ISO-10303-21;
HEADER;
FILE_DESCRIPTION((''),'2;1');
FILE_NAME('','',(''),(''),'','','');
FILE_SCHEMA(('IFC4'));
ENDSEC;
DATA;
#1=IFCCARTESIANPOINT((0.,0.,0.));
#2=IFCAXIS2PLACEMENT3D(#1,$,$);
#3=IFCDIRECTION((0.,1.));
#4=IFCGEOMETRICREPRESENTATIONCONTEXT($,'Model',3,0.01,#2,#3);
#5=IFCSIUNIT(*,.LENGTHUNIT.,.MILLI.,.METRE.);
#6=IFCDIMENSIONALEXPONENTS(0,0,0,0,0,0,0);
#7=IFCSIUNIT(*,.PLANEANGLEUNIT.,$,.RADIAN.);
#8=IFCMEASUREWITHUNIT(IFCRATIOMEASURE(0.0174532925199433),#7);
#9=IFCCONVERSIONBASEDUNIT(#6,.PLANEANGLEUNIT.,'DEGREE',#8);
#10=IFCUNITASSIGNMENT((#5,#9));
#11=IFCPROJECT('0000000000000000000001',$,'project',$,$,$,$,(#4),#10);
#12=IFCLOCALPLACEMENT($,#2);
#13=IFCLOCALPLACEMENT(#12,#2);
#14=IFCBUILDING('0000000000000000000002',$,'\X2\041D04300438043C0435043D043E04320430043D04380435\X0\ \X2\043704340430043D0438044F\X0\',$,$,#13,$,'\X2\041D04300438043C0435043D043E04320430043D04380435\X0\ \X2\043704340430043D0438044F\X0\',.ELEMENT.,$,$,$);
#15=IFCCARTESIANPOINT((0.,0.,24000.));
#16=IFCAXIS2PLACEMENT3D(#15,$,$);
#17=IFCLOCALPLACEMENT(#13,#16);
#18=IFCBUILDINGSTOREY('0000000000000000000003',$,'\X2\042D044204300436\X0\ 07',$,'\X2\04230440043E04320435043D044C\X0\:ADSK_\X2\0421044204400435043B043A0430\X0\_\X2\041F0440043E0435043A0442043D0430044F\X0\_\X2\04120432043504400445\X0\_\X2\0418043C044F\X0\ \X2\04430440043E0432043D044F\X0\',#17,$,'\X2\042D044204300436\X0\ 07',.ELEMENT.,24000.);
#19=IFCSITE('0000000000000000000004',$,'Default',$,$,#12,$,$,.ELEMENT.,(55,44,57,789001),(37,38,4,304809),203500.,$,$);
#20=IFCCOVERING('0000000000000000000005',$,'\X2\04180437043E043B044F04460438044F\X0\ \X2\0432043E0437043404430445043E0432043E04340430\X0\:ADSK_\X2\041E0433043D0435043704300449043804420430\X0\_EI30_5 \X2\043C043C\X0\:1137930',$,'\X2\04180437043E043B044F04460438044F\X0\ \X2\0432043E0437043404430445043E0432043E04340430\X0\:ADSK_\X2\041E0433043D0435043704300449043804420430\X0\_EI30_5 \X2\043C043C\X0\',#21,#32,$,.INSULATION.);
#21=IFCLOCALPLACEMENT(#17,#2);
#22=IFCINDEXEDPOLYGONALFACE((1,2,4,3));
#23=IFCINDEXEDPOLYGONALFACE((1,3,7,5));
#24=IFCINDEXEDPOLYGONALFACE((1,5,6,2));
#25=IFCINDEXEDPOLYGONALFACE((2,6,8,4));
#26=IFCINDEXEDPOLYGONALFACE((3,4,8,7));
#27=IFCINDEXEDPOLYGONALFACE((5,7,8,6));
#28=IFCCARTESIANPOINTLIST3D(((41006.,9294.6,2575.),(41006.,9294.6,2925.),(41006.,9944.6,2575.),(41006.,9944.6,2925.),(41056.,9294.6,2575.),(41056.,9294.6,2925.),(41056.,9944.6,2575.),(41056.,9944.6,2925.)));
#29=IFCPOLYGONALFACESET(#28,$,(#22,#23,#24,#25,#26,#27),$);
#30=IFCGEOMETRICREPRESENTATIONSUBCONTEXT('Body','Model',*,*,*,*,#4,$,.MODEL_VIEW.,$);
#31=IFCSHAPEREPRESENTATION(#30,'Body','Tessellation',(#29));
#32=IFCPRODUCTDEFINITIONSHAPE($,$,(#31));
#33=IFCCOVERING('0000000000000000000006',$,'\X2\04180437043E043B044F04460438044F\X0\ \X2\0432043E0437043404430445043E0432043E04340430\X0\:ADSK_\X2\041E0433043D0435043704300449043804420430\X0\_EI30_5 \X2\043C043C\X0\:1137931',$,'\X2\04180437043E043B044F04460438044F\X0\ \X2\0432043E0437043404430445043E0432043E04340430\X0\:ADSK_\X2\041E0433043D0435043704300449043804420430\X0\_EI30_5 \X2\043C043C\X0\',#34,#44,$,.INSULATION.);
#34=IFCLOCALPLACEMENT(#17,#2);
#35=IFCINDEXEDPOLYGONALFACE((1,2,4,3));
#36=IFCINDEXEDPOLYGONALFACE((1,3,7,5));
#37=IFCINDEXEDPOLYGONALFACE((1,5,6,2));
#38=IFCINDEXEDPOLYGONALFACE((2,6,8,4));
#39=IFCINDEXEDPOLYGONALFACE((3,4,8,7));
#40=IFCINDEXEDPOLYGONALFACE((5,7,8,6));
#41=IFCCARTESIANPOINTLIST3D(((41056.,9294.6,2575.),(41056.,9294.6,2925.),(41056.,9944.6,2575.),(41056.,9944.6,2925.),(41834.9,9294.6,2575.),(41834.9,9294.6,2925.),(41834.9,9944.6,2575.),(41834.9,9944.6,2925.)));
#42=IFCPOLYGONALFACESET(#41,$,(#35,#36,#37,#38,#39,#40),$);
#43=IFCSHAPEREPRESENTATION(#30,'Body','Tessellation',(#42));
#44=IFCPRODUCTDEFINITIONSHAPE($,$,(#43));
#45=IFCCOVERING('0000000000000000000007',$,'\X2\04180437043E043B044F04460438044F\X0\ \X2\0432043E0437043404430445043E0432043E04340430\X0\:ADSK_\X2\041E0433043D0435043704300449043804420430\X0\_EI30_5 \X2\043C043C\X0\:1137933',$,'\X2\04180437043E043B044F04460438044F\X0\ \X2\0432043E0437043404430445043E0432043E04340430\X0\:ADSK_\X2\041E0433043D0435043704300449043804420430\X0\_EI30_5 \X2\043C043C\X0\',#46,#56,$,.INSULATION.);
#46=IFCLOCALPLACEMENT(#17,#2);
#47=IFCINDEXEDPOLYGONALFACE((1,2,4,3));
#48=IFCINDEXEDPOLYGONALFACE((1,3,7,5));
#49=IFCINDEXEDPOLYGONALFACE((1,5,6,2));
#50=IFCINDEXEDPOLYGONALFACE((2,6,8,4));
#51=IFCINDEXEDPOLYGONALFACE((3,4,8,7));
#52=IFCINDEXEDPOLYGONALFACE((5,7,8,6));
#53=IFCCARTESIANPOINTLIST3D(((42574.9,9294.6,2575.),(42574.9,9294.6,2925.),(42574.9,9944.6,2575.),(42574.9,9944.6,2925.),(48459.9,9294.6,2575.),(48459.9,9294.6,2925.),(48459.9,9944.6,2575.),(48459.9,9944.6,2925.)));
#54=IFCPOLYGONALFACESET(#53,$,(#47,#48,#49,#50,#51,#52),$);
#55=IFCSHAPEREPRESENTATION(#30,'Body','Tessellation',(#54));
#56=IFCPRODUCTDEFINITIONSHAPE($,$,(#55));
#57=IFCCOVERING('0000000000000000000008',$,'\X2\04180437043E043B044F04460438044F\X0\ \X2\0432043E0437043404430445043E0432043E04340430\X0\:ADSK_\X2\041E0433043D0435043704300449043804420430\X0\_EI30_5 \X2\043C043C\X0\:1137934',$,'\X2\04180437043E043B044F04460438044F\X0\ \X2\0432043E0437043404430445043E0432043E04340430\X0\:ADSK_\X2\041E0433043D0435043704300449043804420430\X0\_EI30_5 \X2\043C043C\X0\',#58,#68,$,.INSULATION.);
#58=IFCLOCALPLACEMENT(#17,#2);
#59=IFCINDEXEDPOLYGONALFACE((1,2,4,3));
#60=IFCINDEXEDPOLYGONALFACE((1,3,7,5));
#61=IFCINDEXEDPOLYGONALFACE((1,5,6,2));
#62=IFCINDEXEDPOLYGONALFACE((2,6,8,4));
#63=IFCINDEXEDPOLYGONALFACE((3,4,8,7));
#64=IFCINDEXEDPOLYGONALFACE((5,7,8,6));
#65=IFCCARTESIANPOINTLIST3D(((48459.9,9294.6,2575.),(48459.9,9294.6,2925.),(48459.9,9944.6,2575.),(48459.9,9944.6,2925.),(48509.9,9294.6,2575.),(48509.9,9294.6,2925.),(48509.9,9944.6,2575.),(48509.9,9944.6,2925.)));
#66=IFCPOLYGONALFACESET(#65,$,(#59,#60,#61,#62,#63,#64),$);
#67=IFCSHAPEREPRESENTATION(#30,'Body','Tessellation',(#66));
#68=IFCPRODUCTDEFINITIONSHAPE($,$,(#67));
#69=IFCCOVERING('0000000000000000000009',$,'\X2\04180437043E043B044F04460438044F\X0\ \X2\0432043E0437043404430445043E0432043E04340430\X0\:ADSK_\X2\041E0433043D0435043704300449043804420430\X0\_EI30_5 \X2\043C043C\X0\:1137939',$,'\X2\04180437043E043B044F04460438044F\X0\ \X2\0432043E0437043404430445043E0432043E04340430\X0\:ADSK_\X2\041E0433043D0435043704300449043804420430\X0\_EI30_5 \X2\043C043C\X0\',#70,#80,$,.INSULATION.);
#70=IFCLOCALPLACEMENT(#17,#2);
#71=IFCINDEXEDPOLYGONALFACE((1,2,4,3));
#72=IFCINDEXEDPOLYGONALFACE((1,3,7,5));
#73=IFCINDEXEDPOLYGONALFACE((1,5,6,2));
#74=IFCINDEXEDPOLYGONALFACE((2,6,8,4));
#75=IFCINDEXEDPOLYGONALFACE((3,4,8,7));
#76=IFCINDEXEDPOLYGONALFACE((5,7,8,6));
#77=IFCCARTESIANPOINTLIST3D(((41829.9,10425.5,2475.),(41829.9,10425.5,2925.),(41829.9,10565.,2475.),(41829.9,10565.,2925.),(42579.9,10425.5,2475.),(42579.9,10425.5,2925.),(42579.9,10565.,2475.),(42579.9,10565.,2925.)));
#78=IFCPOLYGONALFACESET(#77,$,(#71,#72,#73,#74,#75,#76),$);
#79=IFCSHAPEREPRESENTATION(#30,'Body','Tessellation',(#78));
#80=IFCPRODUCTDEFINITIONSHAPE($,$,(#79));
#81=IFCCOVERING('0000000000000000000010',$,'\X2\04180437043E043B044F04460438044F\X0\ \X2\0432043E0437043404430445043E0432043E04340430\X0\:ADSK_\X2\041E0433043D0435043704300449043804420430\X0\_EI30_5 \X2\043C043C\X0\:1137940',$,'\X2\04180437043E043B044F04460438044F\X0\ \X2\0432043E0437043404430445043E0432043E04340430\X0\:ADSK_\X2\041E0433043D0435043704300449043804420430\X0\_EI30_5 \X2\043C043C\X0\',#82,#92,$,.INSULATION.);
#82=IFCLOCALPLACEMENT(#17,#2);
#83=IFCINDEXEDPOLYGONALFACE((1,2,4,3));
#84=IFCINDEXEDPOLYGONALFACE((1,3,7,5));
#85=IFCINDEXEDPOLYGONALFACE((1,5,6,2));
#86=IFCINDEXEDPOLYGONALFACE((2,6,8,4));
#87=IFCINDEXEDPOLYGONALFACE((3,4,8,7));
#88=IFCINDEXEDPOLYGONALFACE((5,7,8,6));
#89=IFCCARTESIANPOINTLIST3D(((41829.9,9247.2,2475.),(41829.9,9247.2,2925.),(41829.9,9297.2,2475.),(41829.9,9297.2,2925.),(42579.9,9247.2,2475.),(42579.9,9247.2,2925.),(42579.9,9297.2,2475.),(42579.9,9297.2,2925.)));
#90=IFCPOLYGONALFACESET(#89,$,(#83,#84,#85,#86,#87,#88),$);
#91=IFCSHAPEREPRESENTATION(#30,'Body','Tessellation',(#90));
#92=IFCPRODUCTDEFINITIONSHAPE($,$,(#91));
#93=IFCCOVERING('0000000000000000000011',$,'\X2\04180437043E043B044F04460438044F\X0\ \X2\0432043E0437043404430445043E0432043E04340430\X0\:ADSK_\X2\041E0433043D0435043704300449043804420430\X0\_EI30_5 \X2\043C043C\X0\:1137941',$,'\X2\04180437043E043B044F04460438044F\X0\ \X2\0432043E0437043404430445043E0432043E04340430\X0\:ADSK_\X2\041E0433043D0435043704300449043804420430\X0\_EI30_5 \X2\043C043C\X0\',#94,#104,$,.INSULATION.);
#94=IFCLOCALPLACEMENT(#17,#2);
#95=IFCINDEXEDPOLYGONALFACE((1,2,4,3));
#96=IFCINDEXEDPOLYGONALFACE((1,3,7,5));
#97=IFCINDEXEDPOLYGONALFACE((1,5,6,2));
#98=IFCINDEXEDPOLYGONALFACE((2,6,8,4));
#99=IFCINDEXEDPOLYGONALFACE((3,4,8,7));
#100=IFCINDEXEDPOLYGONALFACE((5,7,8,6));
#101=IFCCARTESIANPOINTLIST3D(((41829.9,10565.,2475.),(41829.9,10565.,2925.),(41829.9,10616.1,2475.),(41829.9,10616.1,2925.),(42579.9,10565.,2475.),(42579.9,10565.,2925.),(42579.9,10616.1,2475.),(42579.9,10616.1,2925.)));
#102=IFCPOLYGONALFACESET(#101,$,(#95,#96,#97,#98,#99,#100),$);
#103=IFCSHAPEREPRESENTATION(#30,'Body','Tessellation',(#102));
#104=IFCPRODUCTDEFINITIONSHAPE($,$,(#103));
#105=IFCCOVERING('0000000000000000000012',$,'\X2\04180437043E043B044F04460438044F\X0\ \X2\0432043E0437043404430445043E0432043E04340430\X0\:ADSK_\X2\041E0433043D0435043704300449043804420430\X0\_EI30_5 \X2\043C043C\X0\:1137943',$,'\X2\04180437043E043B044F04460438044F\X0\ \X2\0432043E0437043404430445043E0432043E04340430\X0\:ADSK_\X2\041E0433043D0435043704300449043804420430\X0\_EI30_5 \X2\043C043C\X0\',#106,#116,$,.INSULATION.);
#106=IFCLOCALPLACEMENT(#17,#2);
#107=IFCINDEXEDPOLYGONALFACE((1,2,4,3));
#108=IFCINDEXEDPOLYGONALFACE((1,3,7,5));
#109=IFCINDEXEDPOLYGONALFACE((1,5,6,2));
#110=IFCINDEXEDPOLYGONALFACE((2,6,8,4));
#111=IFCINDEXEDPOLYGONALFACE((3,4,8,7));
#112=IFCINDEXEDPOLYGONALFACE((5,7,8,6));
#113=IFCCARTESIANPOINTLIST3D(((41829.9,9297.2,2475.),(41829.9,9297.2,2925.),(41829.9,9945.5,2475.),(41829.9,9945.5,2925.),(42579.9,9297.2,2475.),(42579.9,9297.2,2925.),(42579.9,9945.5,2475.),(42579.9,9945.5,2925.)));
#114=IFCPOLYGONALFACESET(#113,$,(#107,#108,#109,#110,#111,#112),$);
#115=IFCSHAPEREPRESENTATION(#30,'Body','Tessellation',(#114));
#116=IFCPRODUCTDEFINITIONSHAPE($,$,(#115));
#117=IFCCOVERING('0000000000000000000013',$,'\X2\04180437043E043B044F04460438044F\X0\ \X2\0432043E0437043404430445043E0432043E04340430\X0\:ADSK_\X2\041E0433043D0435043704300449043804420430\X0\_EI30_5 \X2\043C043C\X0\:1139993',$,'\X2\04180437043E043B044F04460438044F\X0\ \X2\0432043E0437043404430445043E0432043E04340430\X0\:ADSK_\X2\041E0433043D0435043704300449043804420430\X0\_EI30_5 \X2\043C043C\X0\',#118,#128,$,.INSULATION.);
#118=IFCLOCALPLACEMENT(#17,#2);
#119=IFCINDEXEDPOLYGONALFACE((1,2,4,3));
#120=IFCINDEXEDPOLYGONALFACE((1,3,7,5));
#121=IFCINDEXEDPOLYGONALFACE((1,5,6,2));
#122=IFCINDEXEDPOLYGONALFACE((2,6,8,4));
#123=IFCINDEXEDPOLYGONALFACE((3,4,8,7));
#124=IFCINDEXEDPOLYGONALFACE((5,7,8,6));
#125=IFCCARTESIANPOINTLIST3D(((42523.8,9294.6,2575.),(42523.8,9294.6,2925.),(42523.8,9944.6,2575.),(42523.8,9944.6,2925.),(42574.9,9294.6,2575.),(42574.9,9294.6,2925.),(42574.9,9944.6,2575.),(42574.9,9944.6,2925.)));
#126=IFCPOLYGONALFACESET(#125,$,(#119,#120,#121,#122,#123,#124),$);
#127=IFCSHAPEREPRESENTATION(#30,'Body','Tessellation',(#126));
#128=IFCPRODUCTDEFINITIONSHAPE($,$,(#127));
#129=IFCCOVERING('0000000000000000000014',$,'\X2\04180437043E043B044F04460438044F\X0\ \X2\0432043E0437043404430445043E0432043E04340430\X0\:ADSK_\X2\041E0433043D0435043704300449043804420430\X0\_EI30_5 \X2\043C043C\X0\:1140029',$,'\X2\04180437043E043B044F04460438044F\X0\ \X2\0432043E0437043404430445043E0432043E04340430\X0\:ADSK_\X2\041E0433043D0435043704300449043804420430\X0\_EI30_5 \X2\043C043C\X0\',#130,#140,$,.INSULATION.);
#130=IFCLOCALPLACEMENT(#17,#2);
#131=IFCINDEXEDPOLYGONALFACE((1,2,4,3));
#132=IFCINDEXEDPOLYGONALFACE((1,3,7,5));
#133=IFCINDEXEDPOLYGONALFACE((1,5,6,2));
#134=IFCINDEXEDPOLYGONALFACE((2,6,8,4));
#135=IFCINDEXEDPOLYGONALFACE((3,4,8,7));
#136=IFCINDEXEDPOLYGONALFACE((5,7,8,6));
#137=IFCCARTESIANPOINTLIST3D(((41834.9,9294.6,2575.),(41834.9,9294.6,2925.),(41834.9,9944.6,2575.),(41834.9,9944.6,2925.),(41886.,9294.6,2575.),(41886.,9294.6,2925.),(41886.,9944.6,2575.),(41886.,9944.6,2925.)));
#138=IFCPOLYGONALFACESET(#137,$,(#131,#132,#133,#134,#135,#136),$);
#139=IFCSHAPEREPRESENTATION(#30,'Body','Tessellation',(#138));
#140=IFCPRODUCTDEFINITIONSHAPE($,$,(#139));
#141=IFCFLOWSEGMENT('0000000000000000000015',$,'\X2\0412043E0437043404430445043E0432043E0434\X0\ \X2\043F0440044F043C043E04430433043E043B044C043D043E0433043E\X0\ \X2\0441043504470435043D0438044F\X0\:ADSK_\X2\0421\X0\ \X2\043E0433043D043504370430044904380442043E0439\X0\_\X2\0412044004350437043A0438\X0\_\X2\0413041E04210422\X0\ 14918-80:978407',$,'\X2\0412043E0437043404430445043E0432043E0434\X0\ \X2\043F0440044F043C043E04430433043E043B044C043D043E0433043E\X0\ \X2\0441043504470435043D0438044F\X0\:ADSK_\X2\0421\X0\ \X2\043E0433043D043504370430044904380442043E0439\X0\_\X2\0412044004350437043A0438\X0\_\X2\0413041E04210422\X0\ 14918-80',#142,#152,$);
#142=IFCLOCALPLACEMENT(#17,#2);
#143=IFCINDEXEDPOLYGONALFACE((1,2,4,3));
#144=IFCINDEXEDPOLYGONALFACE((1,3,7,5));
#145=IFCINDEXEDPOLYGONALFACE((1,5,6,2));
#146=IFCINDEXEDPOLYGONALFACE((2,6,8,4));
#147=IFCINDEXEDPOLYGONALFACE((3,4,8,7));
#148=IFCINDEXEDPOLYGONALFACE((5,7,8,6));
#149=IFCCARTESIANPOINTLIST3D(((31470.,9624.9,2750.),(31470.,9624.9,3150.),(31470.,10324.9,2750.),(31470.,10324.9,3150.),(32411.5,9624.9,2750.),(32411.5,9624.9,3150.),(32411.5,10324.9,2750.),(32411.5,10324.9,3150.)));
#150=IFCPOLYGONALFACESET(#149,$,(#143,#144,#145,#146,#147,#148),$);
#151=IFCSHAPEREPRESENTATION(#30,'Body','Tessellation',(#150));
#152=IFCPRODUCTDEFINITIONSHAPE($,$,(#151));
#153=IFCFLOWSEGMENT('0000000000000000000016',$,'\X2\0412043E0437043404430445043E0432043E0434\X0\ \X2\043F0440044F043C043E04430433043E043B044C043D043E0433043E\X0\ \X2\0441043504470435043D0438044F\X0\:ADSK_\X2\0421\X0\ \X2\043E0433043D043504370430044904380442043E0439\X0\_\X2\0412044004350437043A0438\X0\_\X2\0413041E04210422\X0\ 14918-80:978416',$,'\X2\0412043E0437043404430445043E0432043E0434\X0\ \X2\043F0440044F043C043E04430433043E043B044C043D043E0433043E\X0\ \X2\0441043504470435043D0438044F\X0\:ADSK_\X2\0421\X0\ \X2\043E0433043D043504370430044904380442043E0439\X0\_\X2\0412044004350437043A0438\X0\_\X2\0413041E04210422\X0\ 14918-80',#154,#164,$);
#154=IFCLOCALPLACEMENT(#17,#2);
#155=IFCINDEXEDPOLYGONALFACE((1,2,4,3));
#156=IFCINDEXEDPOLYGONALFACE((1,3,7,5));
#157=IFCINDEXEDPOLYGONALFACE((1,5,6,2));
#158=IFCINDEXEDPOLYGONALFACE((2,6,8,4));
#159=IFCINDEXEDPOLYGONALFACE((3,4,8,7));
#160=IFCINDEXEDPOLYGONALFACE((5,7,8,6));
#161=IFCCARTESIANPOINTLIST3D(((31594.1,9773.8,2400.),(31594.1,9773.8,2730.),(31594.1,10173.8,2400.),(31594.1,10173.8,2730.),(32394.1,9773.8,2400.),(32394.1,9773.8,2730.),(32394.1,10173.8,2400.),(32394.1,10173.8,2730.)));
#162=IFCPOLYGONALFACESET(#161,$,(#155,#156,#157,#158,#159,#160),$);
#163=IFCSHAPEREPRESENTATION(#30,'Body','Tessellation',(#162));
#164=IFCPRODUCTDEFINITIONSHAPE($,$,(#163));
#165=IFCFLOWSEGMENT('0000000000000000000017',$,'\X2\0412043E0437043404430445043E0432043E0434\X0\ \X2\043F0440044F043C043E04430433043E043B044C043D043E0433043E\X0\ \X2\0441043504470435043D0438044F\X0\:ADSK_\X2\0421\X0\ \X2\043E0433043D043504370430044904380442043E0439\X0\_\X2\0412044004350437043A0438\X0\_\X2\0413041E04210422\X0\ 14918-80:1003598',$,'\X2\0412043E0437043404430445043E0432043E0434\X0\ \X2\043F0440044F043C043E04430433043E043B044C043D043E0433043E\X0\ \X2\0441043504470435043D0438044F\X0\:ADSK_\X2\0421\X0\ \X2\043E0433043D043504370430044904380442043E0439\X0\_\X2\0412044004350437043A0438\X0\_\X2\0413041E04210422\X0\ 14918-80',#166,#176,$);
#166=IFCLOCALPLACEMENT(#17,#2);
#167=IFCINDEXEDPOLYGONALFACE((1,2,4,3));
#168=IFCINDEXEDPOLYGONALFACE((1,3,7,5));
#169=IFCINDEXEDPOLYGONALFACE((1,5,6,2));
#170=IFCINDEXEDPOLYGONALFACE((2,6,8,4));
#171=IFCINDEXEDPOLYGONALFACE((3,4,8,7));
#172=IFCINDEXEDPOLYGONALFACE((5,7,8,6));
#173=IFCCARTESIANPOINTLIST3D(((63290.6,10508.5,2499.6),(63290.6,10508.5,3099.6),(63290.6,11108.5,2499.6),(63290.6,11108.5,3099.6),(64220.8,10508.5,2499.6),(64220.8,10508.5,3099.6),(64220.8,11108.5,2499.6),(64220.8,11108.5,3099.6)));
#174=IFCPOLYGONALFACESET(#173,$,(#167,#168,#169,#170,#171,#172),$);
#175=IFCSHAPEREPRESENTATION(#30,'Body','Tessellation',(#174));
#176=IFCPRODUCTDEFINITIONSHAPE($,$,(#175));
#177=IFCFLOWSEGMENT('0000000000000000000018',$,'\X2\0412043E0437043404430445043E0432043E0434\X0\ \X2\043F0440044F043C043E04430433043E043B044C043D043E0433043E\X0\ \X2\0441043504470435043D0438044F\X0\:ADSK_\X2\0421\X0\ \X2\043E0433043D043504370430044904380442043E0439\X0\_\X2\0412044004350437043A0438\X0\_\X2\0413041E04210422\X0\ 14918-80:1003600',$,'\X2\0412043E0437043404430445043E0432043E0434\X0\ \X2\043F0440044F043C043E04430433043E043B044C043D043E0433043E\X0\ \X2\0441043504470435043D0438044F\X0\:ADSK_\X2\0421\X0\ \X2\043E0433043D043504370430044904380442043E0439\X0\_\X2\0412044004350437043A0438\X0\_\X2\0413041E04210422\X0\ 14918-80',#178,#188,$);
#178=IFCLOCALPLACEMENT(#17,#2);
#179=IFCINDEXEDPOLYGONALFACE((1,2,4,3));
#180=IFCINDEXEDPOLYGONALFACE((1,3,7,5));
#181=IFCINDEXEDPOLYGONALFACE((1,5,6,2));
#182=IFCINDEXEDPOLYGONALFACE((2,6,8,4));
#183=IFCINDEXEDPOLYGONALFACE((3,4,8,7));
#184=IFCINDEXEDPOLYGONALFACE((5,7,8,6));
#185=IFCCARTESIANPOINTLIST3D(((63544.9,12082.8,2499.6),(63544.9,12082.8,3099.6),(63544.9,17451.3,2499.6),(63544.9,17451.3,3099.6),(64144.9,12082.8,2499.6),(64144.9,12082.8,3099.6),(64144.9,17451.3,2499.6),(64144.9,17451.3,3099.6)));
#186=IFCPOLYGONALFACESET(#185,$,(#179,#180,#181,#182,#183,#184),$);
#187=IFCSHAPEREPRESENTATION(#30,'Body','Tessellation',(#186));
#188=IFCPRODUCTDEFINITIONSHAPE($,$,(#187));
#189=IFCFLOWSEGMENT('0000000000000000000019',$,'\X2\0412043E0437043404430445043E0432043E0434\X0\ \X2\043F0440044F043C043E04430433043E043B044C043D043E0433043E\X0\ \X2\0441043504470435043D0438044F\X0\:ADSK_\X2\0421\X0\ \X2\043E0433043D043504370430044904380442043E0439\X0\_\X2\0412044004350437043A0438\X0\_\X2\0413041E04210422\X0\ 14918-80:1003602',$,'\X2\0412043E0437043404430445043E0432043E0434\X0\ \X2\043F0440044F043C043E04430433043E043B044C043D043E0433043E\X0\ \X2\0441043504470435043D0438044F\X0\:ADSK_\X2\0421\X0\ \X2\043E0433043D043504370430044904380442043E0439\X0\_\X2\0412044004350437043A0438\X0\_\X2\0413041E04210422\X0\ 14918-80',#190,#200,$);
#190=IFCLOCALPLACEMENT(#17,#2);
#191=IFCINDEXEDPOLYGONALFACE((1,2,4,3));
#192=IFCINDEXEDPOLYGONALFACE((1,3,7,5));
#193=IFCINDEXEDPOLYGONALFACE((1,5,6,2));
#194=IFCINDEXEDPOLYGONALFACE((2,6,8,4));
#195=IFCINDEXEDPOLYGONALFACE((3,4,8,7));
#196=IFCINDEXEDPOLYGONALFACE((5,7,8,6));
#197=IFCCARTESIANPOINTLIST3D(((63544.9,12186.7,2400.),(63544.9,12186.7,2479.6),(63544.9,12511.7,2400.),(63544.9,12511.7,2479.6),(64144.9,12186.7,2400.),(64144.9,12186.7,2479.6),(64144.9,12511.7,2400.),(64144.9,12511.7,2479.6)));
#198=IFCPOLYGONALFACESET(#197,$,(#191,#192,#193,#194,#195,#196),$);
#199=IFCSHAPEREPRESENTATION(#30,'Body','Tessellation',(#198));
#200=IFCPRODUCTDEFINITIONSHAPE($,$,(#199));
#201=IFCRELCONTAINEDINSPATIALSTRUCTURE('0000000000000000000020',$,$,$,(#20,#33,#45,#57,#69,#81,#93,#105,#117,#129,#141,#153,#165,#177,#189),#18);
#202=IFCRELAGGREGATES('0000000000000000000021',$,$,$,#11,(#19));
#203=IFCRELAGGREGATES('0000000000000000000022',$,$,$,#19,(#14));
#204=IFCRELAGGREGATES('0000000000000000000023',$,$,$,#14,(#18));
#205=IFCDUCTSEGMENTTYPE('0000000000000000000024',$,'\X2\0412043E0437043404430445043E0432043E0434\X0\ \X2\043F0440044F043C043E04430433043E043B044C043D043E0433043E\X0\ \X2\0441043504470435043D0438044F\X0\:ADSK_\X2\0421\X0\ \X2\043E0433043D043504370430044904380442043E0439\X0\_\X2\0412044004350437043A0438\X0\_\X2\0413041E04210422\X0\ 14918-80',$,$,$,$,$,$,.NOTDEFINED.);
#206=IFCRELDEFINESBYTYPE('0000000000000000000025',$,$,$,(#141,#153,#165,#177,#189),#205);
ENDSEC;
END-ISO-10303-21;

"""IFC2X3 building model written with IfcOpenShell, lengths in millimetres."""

from ifc_helpers import new_model, entity, si_unit, converted_unit, direction, frame, origin, origin_2d_with_axis, place, context, subcontext, project, spatial, rectangle, extrude, type_object, element, save


model = new_model("IFC2X3")

# Units and contexts
model_context = context("Model", 3, precision=0.01, world=origin(), true_north=direction((0.0, 1.0)))
body_context = subcontext(model_context, "Body", "Model", "MODEL_VIEW")
ifc_project = project(units=[si_unit("LENGTHUNIT", "METRE", prefix="MILLI"), converted_unit("PLANEANGLEUNIT", "DEGREE", entity("IfcRatioMeasure", 0.0174532925199433), si_unit("PLANEANGLEUNIT", "RADIAN"), dimensions=[0, 0, 0, 0, 0, 0, 0])], contexts=[model_context])

# Site, building, storey
site_placement = place(None, origin())
site = spatial("IfcSite", under=ifc_project, at=site_placement, Name="Default", CompositionType="ELEMENT", RefLatitude=(55, 44, 57, 789001), RefLongitude=(37, 38, 4, 304809), RefElevation=203500.0)
building_placement = place(site_placement, origin())
building = spatial("IfcBuilding", under=site, at=building_placement, Name="Наименование здания", LongName="Наименование здания", CompositionType="ELEMENT")
storey_placement = place(building_placement, frame((0.0, 0.0, 24000.0)))
storey = spatial("IfcBuildingStorey", under=building, at=storey_placement, Name="Этаж 07", ObjectType="Уровень:ADSK_Стрелка_Проектная_Вверх_Имя уровня", LongName="Этаж 07", CompositionType="ELEMENT", Elevation=24000.0)

# Coverings
covering_1_placement = place(storey_placement, frame((41006.0, 9294.6, 2575.0)))
element("IfcCovering", 1, at=covering_1_placement, inside=storey, Name="Изоляция воздуховода:ADSK_Огнезащита_EI30_5 мм:1137930", ObjectType="Изоляция воздуховода:ADSK_Огнезащита_EI30_5 мм", PredefinedType="INSULATION", context=body_context, shape_type="SweptSolid", body=[
    extrude(rectangle(XDim=50.0, YDim=650.0, at=origin_2d_with_axis()), frame((25.0, 325.0, 0.0)), (0.0, 0.0, 1.0), 350.0),
])
covering_2_placement = place(storey_placement, frame((41056.0, 9294.6, 2575.0)))
element("IfcCovering", 2, at=covering_2_placement, inside=storey, Name="Изоляция воздуховода:ADSK_Огнезащита_EI30_5 мм:1137931", ObjectType="Изоляция воздуховода:ADSK_Огнезащита_EI30_5 мм", PredefinedType="INSULATION", context=body_context, shape_type="SweptSolid", body=[
    extrude(rectangle(XDim=778.9, YDim=650.0, at=origin_2d_with_axis()), frame((389.4, 325.0, 0.0)), (0.0, 0.0, 1.0), 350.0),
])
covering_3_placement = place(storey_placement, frame((42574.9, 9294.6, 2575.0)))
element("IfcCovering", 3, at=covering_3_placement, inside=storey, Name="Изоляция воздуховода:ADSK_Огнезащита_EI30_5 мм:1137933", ObjectType="Изоляция воздуховода:ADSK_Огнезащита_EI30_5 мм", PredefinedType="INSULATION", context=body_context, shape_type="SweptSolid", body=[
    extrude(rectangle(XDim=5885.0, YDim=650.0, at=origin_2d_with_axis()), frame((2942.5, 325.0, 0.0), z_axis=(0.0, 0.0, 1.0), x_axis=(-1.0, 0.0, 0.0)), (0.0, 0.0, 1.0), 350.0),
])
covering_4_placement = place(storey_placement, frame((48459.9, 9294.6, 2575.0)))
element("IfcCovering", 4, at=covering_4_placement, inside=storey, Name="Изоляция воздуховода:ADSK_Огнезащита_EI30_5 мм:1137934", ObjectType="Изоляция воздуховода:ADSK_Огнезащита_EI30_5 мм", PredefinedType="INSULATION", context=body_context, shape_type="SweptSolid", body=[
    extrude(rectangle(XDim=50.0, YDim=650.0, at=origin_2d_with_axis()), frame((25.0, 325.0, 0.0), z_axis=(0.0, 0.0, 1.0), x_axis=(-1.0, 0.0, 0.0)), (0.0, 0.0, 1.0), 350.0),
])
covering_5_placement = place(storey_placement, frame((41829.9, 10425.5, 2475.0)))
element("IfcCovering", 5, at=covering_5_placement, inside=storey, Name="Изоляция воздуховода:ADSK_Огнезащита_EI30_5 мм:1137939", ObjectType="Изоляция воздуховода:ADSK_Огнезащита_EI30_5 мм", PredefinedType="INSULATION", context=body_context, shape_type="SweptSolid", body=[
    extrude(rectangle(XDim=139.5, YDim=750.0, at=origin_2d_with_axis()), frame((375.0, 69.7, 0.0), z_axis=(0.0, 0.0, 1.0), x_axis=(0.0, 1.0, 0.0)), (0.0, 0.0, 1.0), 450.0),
])
covering_6_placement = place(storey_placement, frame((41829.9, 9247.2, 2475.0)))
element("IfcCovering", 6, at=covering_6_placement, inside=storey, Name="Изоляция воздуховода:ADSK_Огнезащита_EI30_5 мм:1137940", ObjectType="Изоляция воздуховода:ADSK_Огнезащита_EI30_5 мм", PredefinedType="INSULATION", context=body_context, shape_type="SweptSolid", body=[
    extrude(rectangle(XDim=50.0, YDim=750.0, at=origin_2d_with_axis()), frame((375.0, 25.0, 0.0), z_axis=(0.0, 0.0, 1.0), x_axis=(0.0, 1.0, 0.0)), (0.0, 0.0, 1.0), 450.0),
])
covering_7_placement = place(storey_placement, frame((41829.9, 10565.0, 2475.0)))
element("IfcCovering", 7, at=covering_7_placement, inside=storey, Name="Изоляция воздуховода:ADSK_Огнезащита_EI30_5 мм:1137941", ObjectType="Изоляция воздуховода:ADSK_Огнезащита_EI30_5 мм", PredefinedType="INSULATION", context=body_context, shape_type="SweptSolid", body=[
    extrude(rectangle(XDim=750.0, YDim=51.1, at=origin_2d_with_axis()), frame((375.0, 25.6, 0.0)), (0.0, 0.0, 1.0), 450.0),
])
covering_8_placement = place(storey_placement, frame((41829.9, 9297.2, 2475.0)))
element("IfcCovering", 8, at=covering_8_placement, inside=storey, Name="Изоляция воздуховода:ADSK_Огнезащита_EI30_5 мм:1137943", ObjectType="Изоляция воздуховода:ADSK_Огнезащита_EI30_5 мм", PredefinedType="INSULATION", context=body_context, shape_type="SweptSolid", body=[
    extrude(rectangle(XDim=648.3, YDim=750.0, at=origin_2d_with_axis()), frame((375.0, 324.1, 0.0), z_axis=(0.0, 0.0, 1.0), x_axis=(0.0, 1.0, 0.0)), (0.0, 0.0, 1.0), 450.0),
])
covering_9_placement = place(storey_placement, frame((42523.8, 9294.6, 2575.0)))
element("IfcCovering", 9, at=covering_9_placement, inside=storey, Name="Изоляция воздуховода:ADSK_Огнезащита_EI30_5 мм:1139993", ObjectType="Изоляция воздуховода:ADSK_Огнезащита_EI30_5 мм", PredefinedType="INSULATION", context=body_context, shape_type="SweptSolid", body=[
    extrude(rectangle(XDim=51.1, YDim=650.0, at=origin_2d_with_axis()), frame((25.6, 325.0, 0.0), z_axis=(0.0, 0.0, 1.0), x_axis=(-1.0, 0.0, 0.0)), (0.0, 0.0, 1.0), 350.0),
])
covering_10_placement = place(storey_placement, frame((41834.9, 9294.6, 2575.0)))
element("IfcCovering", 10, at=covering_10_placement, inside=storey, Name="Изоляция воздуховода:ADSK_Огнезащита_EI30_5 мм:1140029", ObjectType="Изоляция воздуховода:ADSK_Огнезащита_EI30_5 мм", PredefinedType="INSULATION", context=body_context, shape_type="SweptSolid", body=[
    extrude(rectangle(XDim=650.0, YDim=51.1, at=origin_2d_with_axis()), frame((25.6, 325.0, 0.0), z_axis=(0.0, 0.0, 1.0), x_axis=(0.0, -1.0, 0.0)), (0.0, 0.0, 1.0), 350.0),
])

# Flow segments
duct_segment_type_1 = type_object("IfcDuctSegmentType", Name="Воздуховод прямоугольного сечения:ADSK_С огнезащитой_Врезки_ГОСТ 14918-80", PredefinedType="NOTDEFINED")
flow_segment_1_placement = place(storey_placement, frame((31470.0, 9624.9, 2750.0)))
element("IfcFlowSegment", 11, at=flow_segment_1_placement, inside=storey, type_object=duct_segment_type_1, Name="Воздуховод прямоугольного сечения:ADSK_С огнезащитой_Врезки_ГОСТ 14918-80:978407", ObjectType="Воздуховод прямоугольного сечения:ADSK_С огнезащитой_Врезки_ГОСТ 14918-80", context=body_context, shape_type="SweptSolid", body=[
    extrude(rectangle(XDim=941.5, YDim=700.0, at=origin_2d_with_axis()), frame((470.7, 350.0, 0.0), z_axis=(0.0, 0.0, 1.0), x_axis=(-1.0, 0.0, 0.0)), (0.0, 0.0, 1.0), 400.0),
])
flow_segment_2_placement = place(storey_placement, frame((31594.1, 9773.8, 2400.0)))
element("IfcFlowSegment", 12, at=flow_segment_2_placement, inside=storey, type_object=duct_segment_type_1, Name="Воздуховод прямоугольного сечения:ADSK_С огнезащитой_Врезки_ГОСТ 14918-80:978416", ObjectType="Воздуховод прямоугольного сечения:ADSK_С огнезащитой_Врезки_ГОСТ 14918-80", context=body_context, shape_type="SweptSolid", body=[
    extrude(rectangle(XDim=800.0, YDim=400.0, at=origin_2d_with_axis()), frame((400.0, 200.0, 0.0)), (0.0, 0.0, 1.0), 330.0),
])
flow_segment_3_placement = place(storey_placement, frame((63290.6, 10508.5, 2499.6)))
element("IfcFlowSegment", 13, at=flow_segment_3_placement, inside=storey, type_object=duct_segment_type_1, Name="Воздуховод прямоугольного сечения:ADSK_С огнезащитой_Врезки_ГОСТ 14918-80:1003598", ObjectType="Воздуховод прямоугольного сечения:ADSK_С огнезащитой_Врезки_ГОСТ 14918-80", context=body_context, shape_type="SweptSolid", body=[
    extrude(rectangle(XDim=930.2, YDim=600.0, at=origin_2d_with_axis()), frame((465.1, 300.0, 0.0)), (0.0, 0.0, 1.0), 600.0),
])
flow_segment_4_placement = place(storey_placement, frame((63544.9, 12082.8, 2499.6)))
element("IfcFlowSegment", 14, at=flow_segment_4_placement, inside=storey, type_object=duct_segment_type_1, Name="Воздуховод прямоугольного сечения:ADSK_С огнезащитой_Врезки_ГОСТ 14918-80:1003600", ObjectType="Воздуховод прямоугольного сечения:ADSK_С огнезащитой_Врезки_ГОСТ 14918-80", context=body_context, shape_type="SweptSolid", body=[
    extrude(rectangle(XDim=5368.5, YDim=600.0, at=origin_2d_with_axis()), frame((300.0, 2684.3, 0.0), z_axis=(0.0, 0.0, 1.0), x_axis=(0.0, 1.0, 0.0)), (0.0, 0.0, 1.0), 600.0),
])
flow_segment_5_placement = place(storey_placement, frame((63544.9, 12186.7, 2400.0)))
element("IfcFlowSegment", 15, at=flow_segment_5_placement, inside=storey, type_object=duct_segment_type_1, Name="Воздуховод прямоугольного сечения:ADSK_С огнезащитой_Врезки_ГОСТ 14918-80:1003602", ObjectType="Воздуховод прямоугольного сечения:ADSK_С огнезащитой_Врезки_ГОСТ 14918-80", context=body_context, shape_type="SweptSolid", body=[
    extrude(rectangle(XDim=600.0, YDim=325.0, at=origin_2d_with_axis()), frame((300.0, 162.5, 0.0), z_axis=(0.0, 0.0, 1.0), x_axis=(-1.0, 0.0, 0.0)), (0.0, 0.0, 1.0), 79.6),
])

save(model, "model.ifc")
